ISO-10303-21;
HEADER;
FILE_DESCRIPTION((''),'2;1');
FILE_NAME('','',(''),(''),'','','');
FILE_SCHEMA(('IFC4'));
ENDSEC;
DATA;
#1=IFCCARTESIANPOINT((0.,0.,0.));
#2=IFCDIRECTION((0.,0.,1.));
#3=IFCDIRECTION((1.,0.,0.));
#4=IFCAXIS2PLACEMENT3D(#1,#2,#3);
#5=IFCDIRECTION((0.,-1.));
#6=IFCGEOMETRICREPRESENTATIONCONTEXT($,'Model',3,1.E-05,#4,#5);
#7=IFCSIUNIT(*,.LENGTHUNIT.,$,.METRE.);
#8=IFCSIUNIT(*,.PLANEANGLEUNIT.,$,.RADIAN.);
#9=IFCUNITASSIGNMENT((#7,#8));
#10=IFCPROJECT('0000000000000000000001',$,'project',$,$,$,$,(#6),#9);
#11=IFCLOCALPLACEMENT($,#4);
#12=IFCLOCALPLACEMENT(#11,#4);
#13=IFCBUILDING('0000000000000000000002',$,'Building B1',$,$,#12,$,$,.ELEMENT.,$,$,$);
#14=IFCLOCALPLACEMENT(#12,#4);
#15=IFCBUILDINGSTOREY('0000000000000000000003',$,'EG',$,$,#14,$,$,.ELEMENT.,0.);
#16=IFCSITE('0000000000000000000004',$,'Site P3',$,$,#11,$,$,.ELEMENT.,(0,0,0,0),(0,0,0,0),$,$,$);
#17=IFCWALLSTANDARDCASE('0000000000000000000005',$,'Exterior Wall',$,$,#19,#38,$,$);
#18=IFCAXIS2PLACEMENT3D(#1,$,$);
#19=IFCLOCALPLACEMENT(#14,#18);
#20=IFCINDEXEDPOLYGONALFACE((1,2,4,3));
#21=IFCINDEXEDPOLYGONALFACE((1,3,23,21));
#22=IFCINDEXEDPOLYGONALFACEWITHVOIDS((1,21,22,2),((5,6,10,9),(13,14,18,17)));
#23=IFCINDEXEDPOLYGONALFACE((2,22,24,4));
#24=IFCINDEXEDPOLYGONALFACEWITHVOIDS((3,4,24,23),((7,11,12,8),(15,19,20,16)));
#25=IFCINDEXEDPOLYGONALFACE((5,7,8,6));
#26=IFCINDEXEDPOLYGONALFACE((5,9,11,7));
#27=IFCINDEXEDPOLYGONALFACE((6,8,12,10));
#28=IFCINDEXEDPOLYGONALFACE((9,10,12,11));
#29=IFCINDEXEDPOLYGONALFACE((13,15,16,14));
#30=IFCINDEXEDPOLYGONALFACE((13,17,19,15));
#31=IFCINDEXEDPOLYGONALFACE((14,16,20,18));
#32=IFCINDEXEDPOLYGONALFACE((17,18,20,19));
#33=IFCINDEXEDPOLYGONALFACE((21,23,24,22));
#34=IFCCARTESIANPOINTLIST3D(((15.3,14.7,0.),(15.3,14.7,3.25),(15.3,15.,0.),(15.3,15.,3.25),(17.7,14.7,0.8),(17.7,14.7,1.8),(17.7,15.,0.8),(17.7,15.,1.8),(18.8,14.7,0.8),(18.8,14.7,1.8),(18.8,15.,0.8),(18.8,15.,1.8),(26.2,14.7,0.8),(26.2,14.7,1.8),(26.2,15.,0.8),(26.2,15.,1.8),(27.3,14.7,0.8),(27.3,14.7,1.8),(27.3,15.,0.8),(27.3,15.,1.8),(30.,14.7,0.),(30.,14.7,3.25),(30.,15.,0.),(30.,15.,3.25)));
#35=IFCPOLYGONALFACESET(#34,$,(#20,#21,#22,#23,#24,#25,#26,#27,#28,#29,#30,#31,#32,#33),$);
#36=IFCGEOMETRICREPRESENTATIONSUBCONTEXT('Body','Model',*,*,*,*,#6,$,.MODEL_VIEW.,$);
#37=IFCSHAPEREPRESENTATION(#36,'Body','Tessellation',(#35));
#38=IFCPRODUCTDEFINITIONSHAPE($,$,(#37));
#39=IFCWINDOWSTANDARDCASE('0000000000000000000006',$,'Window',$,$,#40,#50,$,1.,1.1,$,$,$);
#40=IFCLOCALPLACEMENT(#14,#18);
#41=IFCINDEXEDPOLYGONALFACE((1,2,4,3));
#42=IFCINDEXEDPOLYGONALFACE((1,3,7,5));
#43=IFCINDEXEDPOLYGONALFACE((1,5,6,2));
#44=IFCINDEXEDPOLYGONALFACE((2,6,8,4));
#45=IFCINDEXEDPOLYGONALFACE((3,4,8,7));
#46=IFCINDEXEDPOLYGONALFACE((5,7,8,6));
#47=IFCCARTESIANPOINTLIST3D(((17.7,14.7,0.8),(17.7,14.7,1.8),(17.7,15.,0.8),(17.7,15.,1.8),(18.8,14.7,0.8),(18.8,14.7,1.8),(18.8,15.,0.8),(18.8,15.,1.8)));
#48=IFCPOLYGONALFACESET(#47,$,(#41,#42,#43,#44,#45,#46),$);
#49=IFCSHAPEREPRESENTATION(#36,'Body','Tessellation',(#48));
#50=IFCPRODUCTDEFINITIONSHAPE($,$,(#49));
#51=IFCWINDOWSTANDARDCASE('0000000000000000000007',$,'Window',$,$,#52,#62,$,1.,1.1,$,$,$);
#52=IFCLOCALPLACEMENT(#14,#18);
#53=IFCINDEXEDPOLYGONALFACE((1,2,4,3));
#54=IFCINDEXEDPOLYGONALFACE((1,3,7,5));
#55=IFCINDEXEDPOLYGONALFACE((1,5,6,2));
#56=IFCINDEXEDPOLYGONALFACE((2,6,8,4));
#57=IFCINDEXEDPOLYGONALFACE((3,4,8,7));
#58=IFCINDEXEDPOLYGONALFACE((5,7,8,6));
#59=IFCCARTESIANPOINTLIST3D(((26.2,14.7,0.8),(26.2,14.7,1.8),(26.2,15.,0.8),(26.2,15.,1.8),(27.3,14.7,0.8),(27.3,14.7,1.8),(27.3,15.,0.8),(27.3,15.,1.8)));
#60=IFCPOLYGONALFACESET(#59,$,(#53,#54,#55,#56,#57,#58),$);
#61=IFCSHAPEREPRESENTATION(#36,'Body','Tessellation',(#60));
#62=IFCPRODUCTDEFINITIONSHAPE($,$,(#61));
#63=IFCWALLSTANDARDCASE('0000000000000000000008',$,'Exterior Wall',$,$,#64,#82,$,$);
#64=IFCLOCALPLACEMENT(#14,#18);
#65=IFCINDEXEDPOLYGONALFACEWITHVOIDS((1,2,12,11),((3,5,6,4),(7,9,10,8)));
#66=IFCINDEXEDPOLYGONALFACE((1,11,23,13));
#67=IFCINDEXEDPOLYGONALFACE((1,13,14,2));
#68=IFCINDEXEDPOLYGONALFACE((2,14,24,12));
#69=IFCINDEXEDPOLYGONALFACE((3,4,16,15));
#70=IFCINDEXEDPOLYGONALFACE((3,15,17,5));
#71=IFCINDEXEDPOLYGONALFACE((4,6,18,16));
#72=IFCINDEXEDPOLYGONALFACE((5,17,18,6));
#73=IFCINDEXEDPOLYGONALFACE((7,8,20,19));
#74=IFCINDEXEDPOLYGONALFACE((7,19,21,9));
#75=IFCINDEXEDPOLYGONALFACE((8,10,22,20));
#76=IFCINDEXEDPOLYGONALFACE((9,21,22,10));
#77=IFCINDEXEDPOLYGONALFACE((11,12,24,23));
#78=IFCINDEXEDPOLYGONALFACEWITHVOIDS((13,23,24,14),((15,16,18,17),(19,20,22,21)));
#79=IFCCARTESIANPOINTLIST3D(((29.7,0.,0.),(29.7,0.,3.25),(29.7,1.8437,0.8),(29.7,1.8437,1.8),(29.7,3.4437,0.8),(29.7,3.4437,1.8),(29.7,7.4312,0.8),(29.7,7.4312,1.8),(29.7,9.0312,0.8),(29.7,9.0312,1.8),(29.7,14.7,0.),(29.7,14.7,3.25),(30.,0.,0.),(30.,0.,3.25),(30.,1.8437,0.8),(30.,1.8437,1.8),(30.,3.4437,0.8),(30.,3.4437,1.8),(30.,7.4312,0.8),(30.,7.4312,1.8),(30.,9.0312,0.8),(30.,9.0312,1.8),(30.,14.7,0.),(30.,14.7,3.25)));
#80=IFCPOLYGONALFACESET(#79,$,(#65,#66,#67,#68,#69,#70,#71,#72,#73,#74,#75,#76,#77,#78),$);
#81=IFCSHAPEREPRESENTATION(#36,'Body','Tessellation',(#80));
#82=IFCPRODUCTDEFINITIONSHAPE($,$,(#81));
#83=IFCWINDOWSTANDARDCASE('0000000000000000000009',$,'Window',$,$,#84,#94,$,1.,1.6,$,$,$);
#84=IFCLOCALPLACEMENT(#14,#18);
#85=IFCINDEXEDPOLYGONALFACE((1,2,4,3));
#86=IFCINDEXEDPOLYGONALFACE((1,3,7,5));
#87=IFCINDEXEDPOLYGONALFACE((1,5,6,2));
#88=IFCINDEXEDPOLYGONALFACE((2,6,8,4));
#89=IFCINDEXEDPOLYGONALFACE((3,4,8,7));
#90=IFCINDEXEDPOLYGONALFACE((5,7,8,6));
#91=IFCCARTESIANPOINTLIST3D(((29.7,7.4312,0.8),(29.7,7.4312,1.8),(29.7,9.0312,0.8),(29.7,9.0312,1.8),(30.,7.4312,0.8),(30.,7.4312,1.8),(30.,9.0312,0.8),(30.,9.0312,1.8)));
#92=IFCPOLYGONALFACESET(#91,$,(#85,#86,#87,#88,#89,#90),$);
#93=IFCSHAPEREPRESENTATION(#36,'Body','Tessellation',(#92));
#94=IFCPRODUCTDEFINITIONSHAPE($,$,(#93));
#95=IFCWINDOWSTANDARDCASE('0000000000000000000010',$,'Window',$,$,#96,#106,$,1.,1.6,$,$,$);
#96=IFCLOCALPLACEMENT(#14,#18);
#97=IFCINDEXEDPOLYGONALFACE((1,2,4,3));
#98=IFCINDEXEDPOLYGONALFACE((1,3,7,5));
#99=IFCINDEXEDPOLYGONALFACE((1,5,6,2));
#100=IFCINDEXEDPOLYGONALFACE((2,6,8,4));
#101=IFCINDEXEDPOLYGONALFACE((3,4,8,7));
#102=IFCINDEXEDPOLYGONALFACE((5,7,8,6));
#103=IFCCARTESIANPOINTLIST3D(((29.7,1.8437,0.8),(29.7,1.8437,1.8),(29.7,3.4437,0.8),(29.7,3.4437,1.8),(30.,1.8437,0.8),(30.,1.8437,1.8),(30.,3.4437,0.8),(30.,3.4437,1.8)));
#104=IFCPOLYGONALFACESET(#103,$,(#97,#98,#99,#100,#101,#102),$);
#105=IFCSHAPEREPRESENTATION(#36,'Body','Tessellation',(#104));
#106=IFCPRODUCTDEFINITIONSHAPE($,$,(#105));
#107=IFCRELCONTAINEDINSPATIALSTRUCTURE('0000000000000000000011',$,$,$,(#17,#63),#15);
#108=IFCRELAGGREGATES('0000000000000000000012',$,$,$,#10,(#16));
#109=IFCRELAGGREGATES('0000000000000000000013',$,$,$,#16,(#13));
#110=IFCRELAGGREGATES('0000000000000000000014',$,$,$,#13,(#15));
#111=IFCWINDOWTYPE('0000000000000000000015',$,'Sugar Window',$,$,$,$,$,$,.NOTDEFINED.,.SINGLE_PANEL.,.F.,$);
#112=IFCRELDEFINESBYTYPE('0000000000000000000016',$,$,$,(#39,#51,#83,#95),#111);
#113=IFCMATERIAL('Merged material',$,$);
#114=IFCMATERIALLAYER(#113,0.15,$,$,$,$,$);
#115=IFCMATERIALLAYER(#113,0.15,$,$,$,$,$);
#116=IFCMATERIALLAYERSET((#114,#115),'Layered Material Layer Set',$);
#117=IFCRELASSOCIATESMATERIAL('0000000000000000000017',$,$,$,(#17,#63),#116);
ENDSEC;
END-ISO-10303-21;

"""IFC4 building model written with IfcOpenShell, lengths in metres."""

from ifc_helpers import new_model, si_unit, direction, frame, origin_with_axes, place, context, subcontext, project, spatial, polyline, outline, extrude, source, transform, mapped, material, layer, layer_set, layer_usage, type_object, element, fill, save


model = new_model("IFC4")

# Units and contexts
model_context = context("Model", 3, precision=1e-05, world=origin_with_axes(), true_north=direction((0.0, -1.0)))
body_context = subcontext(model_context, "Body", "Model", "MODEL_VIEW")
ifc_project = project(units=[si_unit("LENGTHUNIT", "METRE"), si_unit("PLANEANGLEUNIT", "RADIAN")], contexts=[model_context])

# Site, building, storey
site_placement = place(None, origin_with_axes())
site = spatial("IfcSite", under=ifc_project, at=site_placement, Name="Site P3", CompositionType="ELEMENT", RefLatitude=(0, 0, 0, 0), RefLongitude=(0, 0, 0, 0))
building_placement = place(site_placement, origin_with_axes())
building = spatial("IfcBuilding", under=site, at=building_placement, Name="Building B1", CompositionType="ELEMENT")
storey_placement = place(building_placement, origin_with_axes())
storey = spatial("IfcBuildingStorey", under=building, at=storey_placement, Name="EG", CompositionType="ELEMENT", Elevation=0.0)

# Walls, openings, windows
ifc_material = material(Name="Merged material")
ifc_layer_1 = layer(ifc_material, 0.15)
ifc_layer_2 = layer(ifc_material, 0.15)
ifc_layer_set_1 = layer_set([ifc_layer_1, ifc_layer_2], Name="Layered Material Layer Set")
ifc_layer_usage_1 = layer_usage(ifc_layer_set_1, "AXIS2", "POSITIVE", -0.15)
wall_1_placement = place(storey_placement, frame((30.0, 14.85, 0.0), z_axis=(0.0, 0.0, 1.0), x_axis=(-1.0, 0.0, 0.0)))
wall_1 = element("IfcWallStandardCase", 1, at=wall_1_placement, inside=storey, material=ifc_layer_usage_1, Name="Exterior Wall", context=body_context, shape_type="SweptSolid", body=[
    extrude(outline(polyline([(0.0, 0.15), (14.7, 0.15), (14.7, -0.15), (0.0, -0.15), (0.0, 0.15)])), origin_with_axes(), (0.0, 0.0, 1.0), 3.25),
])
opening_1_placement = place(wall_1_placement, frame((11.2, 0.0, 0.8), z_axis=(0.0, 0.0, 1.0), x_axis=(1.0, 0.0, 0.0)))
opening_1 = element("IfcOpeningStandardCase", 2, at=opening_1_placement, cuts=wall_1, context=body_context, shape_type="SweptSolid", body=[
    extrude(outline(polyline([(0.0, 0.0), (0.0, 1.1), (1.0, 1.1), (1.0, 0.0), (0.0, 0.0)])), frame((0.0, -0.15, 0.0), z_axis=(0.0, 1.0, 0.0), x_axis=(0.0, 0.0, 1.0)), (0.0, 0.0, 1.0), 0.3),
])
opening_2_placement = place(wall_1_placement, frame((2.7, 0.0, 0.8), z_axis=(0.0, 0.0, 1.0), x_axis=(1.0, 0.0, 0.0)))
opening_2 = element("IfcOpeningStandardCase", 3, at=opening_2_placement, cuts=wall_1, context=body_context, shape_type="SweptSolid", body=[
    extrude(outline(polyline([(0.0, 0.0), (0.0, 1.1), (1.0, 1.1), (1.0, 0.0), (0.0, 0.0)])), frame((0.0, -0.15, 0.0), z_axis=(0.0, 1.0, 0.0), x_axis=(0.0, 0.0, 1.0)), (0.0, 0.0, 1.0), 0.3),
])
window_type = type_object("IfcWindowType", Name="Sugar Window", ParameterTakesPrecedence=False, PartitioningType="SINGLE_PANEL", PredefinedType="NOTDEFINED")
shared_shape_1 = source(origin_with_axes(), body_context, "Body", "SweptSolid", [
    extrude(outline(polyline([(0.0, 0.0), (0.0, 1.1), (1.0, 1.1), (1.0, 0.0), (0.0, 0.0)])), frame((0.0, -0.15, 0.0), z_axis=(0.0, 1.0, 0.0), x_axis=(0.0, 0.0, 1.0)), (0.0, 0.0, 1.0), 0.3),
])
window_1_placement = place(opening_1_placement, origin_with_axes())
window_1 = element("IfcWindowStandardCase", 4, at=window_1_placement, type_object=window_type, Name="Window", OverallHeight=1.0, OverallWidth=1.1, context=body_context, shape_type="MappedRepresentation", body=[
    mapped(shared_shape_1, transform((0.0, 0.0, 0.0))),
])
fill(opening_1, window_1)
window_2_placement = place(opening_2_placement, origin_with_axes())
window_2 = element("IfcWindowStandardCase", 5, at=window_2_placement, type_object=window_type, Name="Window", OverallHeight=1.0, OverallWidth=1.1, context=body_context, shape_type="MappedRepresentation", body=[
    mapped(shared_shape_1, transform((0.0, 0.0, 0.0))),
])
fill(opening_2, window_2)
wall_2_placement = place(storey_placement, frame((29.85, 0.0, 0.0), z_axis=(0.0, 0.0, 1.0), x_axis=(0.0, 1.0, 0.0)))
wall_2 = element("IfcWallStandardCase", 6, at=wall_2_placement, inside=storey, material=ifc_layer_usage_1, Name="Exterior Wall", context=body_context, shape_type="SweptSolid", body=[
    extrude(outline(polyline([(0.0, 0.15), (14.7, 0.15), (14.7, -0.15), (0.0, -0.15), (0.0, 0.15)])), origin_with_axes(), (0.0, 0.0, 1.0), 3.25),
])
opening_3_placement = place(wall_2_placement, frame((7.4312, 0.0, 0.8), z_axis=(0.0, 0.0, 1.0), x_axis=(1.0, 0.0, 0.0)))
opening_3 = element("IfcOpeningStandardCase", 7, at=opening_3_placement, cuts=wall_2, context=body_context, shape_type="SweptSolid", body=[
    extrude(outline(polyline([(0.0, 0.0), (0.0, 1.6), (1.0, 1.6), (1.0, 0.0), (0.0, 0.0)])), frame((0.0, -0.15, 0.0), z_axis=(0.0, 1.0, 0.0), x_axis=(0.0, 0.0, 1.0)), (0.0, 0.0, 1.0), 0.3),
])
opening_4_placement = place(wall_2_placement, frame((1.8437, 0.0, 0.8), z_axis=(0.0, 0.0, 1.0), x_axis=(1.0, 0.0, 0.0)))
opening_4 = element("IfcOpeningStandardCase", 8, at=opening_4_placement, cuts=wall_2, context=body_context, shape_type="SweptSolid", body=[
    extrude(outline(polyline([(0.0, 0.0), (0.0, 1.6), (1.0, 1.6), (1.0, 0.0), (0.0, 0.0)])), frame((0.0, -0.15, 0.0), z_axis=(0.0, 1.0, 0.0), x_axis=(0.0, 0.0, 1.0)), (0.0, 0.0, 1.0), 0.3),
])
shared_shape_2 = source(origin_with_axes(), body_context, "Body", "SweptSolid", [
    extrude(outline(polyline([(0.0, 0.0), (0.0, 1.6), (1.0, 1.6), (1.0, 0.0), (0.0, 0.0)])), frame((0.0, -0.15, 0.0), z_axis=(0.0, 1.0, 0.0), x_axis=(0.0, 0.0, 1.0)), (0.0, 0.0, 1.0), 0.3),
])
window_3_placement = place(opening_3_placement, origin_with_axes())
window_3 = element("IfcWindowStandardCase", 9, at=window_3_placement, type_object=window_type, Name="Window", OverallHeight=1.0, OverallWidth=1.6, context=body_context, shape_type="MappedRepresentation", body=[
    mapped(shared_shape_2, transform((0.0, 0.0, 0.0))),
])
fill(opening_3, window_3)
window_4_placement = place(opening_4_placement, origin_with_axes())
window_4 = element("IfcWindowStandardCase", 10, at=window_4_placement, type_object=window_type, Name="Window", OverallHeight=1.0, OverallWidth=1.6, context=body_context, shape_type="MappedRepresentation", body=[
    mapped(shared_shape_2, transform((0.0, 0.0, 0.0))),
])
fill(opening_4, window_4)

save(model, "model.ifc")
